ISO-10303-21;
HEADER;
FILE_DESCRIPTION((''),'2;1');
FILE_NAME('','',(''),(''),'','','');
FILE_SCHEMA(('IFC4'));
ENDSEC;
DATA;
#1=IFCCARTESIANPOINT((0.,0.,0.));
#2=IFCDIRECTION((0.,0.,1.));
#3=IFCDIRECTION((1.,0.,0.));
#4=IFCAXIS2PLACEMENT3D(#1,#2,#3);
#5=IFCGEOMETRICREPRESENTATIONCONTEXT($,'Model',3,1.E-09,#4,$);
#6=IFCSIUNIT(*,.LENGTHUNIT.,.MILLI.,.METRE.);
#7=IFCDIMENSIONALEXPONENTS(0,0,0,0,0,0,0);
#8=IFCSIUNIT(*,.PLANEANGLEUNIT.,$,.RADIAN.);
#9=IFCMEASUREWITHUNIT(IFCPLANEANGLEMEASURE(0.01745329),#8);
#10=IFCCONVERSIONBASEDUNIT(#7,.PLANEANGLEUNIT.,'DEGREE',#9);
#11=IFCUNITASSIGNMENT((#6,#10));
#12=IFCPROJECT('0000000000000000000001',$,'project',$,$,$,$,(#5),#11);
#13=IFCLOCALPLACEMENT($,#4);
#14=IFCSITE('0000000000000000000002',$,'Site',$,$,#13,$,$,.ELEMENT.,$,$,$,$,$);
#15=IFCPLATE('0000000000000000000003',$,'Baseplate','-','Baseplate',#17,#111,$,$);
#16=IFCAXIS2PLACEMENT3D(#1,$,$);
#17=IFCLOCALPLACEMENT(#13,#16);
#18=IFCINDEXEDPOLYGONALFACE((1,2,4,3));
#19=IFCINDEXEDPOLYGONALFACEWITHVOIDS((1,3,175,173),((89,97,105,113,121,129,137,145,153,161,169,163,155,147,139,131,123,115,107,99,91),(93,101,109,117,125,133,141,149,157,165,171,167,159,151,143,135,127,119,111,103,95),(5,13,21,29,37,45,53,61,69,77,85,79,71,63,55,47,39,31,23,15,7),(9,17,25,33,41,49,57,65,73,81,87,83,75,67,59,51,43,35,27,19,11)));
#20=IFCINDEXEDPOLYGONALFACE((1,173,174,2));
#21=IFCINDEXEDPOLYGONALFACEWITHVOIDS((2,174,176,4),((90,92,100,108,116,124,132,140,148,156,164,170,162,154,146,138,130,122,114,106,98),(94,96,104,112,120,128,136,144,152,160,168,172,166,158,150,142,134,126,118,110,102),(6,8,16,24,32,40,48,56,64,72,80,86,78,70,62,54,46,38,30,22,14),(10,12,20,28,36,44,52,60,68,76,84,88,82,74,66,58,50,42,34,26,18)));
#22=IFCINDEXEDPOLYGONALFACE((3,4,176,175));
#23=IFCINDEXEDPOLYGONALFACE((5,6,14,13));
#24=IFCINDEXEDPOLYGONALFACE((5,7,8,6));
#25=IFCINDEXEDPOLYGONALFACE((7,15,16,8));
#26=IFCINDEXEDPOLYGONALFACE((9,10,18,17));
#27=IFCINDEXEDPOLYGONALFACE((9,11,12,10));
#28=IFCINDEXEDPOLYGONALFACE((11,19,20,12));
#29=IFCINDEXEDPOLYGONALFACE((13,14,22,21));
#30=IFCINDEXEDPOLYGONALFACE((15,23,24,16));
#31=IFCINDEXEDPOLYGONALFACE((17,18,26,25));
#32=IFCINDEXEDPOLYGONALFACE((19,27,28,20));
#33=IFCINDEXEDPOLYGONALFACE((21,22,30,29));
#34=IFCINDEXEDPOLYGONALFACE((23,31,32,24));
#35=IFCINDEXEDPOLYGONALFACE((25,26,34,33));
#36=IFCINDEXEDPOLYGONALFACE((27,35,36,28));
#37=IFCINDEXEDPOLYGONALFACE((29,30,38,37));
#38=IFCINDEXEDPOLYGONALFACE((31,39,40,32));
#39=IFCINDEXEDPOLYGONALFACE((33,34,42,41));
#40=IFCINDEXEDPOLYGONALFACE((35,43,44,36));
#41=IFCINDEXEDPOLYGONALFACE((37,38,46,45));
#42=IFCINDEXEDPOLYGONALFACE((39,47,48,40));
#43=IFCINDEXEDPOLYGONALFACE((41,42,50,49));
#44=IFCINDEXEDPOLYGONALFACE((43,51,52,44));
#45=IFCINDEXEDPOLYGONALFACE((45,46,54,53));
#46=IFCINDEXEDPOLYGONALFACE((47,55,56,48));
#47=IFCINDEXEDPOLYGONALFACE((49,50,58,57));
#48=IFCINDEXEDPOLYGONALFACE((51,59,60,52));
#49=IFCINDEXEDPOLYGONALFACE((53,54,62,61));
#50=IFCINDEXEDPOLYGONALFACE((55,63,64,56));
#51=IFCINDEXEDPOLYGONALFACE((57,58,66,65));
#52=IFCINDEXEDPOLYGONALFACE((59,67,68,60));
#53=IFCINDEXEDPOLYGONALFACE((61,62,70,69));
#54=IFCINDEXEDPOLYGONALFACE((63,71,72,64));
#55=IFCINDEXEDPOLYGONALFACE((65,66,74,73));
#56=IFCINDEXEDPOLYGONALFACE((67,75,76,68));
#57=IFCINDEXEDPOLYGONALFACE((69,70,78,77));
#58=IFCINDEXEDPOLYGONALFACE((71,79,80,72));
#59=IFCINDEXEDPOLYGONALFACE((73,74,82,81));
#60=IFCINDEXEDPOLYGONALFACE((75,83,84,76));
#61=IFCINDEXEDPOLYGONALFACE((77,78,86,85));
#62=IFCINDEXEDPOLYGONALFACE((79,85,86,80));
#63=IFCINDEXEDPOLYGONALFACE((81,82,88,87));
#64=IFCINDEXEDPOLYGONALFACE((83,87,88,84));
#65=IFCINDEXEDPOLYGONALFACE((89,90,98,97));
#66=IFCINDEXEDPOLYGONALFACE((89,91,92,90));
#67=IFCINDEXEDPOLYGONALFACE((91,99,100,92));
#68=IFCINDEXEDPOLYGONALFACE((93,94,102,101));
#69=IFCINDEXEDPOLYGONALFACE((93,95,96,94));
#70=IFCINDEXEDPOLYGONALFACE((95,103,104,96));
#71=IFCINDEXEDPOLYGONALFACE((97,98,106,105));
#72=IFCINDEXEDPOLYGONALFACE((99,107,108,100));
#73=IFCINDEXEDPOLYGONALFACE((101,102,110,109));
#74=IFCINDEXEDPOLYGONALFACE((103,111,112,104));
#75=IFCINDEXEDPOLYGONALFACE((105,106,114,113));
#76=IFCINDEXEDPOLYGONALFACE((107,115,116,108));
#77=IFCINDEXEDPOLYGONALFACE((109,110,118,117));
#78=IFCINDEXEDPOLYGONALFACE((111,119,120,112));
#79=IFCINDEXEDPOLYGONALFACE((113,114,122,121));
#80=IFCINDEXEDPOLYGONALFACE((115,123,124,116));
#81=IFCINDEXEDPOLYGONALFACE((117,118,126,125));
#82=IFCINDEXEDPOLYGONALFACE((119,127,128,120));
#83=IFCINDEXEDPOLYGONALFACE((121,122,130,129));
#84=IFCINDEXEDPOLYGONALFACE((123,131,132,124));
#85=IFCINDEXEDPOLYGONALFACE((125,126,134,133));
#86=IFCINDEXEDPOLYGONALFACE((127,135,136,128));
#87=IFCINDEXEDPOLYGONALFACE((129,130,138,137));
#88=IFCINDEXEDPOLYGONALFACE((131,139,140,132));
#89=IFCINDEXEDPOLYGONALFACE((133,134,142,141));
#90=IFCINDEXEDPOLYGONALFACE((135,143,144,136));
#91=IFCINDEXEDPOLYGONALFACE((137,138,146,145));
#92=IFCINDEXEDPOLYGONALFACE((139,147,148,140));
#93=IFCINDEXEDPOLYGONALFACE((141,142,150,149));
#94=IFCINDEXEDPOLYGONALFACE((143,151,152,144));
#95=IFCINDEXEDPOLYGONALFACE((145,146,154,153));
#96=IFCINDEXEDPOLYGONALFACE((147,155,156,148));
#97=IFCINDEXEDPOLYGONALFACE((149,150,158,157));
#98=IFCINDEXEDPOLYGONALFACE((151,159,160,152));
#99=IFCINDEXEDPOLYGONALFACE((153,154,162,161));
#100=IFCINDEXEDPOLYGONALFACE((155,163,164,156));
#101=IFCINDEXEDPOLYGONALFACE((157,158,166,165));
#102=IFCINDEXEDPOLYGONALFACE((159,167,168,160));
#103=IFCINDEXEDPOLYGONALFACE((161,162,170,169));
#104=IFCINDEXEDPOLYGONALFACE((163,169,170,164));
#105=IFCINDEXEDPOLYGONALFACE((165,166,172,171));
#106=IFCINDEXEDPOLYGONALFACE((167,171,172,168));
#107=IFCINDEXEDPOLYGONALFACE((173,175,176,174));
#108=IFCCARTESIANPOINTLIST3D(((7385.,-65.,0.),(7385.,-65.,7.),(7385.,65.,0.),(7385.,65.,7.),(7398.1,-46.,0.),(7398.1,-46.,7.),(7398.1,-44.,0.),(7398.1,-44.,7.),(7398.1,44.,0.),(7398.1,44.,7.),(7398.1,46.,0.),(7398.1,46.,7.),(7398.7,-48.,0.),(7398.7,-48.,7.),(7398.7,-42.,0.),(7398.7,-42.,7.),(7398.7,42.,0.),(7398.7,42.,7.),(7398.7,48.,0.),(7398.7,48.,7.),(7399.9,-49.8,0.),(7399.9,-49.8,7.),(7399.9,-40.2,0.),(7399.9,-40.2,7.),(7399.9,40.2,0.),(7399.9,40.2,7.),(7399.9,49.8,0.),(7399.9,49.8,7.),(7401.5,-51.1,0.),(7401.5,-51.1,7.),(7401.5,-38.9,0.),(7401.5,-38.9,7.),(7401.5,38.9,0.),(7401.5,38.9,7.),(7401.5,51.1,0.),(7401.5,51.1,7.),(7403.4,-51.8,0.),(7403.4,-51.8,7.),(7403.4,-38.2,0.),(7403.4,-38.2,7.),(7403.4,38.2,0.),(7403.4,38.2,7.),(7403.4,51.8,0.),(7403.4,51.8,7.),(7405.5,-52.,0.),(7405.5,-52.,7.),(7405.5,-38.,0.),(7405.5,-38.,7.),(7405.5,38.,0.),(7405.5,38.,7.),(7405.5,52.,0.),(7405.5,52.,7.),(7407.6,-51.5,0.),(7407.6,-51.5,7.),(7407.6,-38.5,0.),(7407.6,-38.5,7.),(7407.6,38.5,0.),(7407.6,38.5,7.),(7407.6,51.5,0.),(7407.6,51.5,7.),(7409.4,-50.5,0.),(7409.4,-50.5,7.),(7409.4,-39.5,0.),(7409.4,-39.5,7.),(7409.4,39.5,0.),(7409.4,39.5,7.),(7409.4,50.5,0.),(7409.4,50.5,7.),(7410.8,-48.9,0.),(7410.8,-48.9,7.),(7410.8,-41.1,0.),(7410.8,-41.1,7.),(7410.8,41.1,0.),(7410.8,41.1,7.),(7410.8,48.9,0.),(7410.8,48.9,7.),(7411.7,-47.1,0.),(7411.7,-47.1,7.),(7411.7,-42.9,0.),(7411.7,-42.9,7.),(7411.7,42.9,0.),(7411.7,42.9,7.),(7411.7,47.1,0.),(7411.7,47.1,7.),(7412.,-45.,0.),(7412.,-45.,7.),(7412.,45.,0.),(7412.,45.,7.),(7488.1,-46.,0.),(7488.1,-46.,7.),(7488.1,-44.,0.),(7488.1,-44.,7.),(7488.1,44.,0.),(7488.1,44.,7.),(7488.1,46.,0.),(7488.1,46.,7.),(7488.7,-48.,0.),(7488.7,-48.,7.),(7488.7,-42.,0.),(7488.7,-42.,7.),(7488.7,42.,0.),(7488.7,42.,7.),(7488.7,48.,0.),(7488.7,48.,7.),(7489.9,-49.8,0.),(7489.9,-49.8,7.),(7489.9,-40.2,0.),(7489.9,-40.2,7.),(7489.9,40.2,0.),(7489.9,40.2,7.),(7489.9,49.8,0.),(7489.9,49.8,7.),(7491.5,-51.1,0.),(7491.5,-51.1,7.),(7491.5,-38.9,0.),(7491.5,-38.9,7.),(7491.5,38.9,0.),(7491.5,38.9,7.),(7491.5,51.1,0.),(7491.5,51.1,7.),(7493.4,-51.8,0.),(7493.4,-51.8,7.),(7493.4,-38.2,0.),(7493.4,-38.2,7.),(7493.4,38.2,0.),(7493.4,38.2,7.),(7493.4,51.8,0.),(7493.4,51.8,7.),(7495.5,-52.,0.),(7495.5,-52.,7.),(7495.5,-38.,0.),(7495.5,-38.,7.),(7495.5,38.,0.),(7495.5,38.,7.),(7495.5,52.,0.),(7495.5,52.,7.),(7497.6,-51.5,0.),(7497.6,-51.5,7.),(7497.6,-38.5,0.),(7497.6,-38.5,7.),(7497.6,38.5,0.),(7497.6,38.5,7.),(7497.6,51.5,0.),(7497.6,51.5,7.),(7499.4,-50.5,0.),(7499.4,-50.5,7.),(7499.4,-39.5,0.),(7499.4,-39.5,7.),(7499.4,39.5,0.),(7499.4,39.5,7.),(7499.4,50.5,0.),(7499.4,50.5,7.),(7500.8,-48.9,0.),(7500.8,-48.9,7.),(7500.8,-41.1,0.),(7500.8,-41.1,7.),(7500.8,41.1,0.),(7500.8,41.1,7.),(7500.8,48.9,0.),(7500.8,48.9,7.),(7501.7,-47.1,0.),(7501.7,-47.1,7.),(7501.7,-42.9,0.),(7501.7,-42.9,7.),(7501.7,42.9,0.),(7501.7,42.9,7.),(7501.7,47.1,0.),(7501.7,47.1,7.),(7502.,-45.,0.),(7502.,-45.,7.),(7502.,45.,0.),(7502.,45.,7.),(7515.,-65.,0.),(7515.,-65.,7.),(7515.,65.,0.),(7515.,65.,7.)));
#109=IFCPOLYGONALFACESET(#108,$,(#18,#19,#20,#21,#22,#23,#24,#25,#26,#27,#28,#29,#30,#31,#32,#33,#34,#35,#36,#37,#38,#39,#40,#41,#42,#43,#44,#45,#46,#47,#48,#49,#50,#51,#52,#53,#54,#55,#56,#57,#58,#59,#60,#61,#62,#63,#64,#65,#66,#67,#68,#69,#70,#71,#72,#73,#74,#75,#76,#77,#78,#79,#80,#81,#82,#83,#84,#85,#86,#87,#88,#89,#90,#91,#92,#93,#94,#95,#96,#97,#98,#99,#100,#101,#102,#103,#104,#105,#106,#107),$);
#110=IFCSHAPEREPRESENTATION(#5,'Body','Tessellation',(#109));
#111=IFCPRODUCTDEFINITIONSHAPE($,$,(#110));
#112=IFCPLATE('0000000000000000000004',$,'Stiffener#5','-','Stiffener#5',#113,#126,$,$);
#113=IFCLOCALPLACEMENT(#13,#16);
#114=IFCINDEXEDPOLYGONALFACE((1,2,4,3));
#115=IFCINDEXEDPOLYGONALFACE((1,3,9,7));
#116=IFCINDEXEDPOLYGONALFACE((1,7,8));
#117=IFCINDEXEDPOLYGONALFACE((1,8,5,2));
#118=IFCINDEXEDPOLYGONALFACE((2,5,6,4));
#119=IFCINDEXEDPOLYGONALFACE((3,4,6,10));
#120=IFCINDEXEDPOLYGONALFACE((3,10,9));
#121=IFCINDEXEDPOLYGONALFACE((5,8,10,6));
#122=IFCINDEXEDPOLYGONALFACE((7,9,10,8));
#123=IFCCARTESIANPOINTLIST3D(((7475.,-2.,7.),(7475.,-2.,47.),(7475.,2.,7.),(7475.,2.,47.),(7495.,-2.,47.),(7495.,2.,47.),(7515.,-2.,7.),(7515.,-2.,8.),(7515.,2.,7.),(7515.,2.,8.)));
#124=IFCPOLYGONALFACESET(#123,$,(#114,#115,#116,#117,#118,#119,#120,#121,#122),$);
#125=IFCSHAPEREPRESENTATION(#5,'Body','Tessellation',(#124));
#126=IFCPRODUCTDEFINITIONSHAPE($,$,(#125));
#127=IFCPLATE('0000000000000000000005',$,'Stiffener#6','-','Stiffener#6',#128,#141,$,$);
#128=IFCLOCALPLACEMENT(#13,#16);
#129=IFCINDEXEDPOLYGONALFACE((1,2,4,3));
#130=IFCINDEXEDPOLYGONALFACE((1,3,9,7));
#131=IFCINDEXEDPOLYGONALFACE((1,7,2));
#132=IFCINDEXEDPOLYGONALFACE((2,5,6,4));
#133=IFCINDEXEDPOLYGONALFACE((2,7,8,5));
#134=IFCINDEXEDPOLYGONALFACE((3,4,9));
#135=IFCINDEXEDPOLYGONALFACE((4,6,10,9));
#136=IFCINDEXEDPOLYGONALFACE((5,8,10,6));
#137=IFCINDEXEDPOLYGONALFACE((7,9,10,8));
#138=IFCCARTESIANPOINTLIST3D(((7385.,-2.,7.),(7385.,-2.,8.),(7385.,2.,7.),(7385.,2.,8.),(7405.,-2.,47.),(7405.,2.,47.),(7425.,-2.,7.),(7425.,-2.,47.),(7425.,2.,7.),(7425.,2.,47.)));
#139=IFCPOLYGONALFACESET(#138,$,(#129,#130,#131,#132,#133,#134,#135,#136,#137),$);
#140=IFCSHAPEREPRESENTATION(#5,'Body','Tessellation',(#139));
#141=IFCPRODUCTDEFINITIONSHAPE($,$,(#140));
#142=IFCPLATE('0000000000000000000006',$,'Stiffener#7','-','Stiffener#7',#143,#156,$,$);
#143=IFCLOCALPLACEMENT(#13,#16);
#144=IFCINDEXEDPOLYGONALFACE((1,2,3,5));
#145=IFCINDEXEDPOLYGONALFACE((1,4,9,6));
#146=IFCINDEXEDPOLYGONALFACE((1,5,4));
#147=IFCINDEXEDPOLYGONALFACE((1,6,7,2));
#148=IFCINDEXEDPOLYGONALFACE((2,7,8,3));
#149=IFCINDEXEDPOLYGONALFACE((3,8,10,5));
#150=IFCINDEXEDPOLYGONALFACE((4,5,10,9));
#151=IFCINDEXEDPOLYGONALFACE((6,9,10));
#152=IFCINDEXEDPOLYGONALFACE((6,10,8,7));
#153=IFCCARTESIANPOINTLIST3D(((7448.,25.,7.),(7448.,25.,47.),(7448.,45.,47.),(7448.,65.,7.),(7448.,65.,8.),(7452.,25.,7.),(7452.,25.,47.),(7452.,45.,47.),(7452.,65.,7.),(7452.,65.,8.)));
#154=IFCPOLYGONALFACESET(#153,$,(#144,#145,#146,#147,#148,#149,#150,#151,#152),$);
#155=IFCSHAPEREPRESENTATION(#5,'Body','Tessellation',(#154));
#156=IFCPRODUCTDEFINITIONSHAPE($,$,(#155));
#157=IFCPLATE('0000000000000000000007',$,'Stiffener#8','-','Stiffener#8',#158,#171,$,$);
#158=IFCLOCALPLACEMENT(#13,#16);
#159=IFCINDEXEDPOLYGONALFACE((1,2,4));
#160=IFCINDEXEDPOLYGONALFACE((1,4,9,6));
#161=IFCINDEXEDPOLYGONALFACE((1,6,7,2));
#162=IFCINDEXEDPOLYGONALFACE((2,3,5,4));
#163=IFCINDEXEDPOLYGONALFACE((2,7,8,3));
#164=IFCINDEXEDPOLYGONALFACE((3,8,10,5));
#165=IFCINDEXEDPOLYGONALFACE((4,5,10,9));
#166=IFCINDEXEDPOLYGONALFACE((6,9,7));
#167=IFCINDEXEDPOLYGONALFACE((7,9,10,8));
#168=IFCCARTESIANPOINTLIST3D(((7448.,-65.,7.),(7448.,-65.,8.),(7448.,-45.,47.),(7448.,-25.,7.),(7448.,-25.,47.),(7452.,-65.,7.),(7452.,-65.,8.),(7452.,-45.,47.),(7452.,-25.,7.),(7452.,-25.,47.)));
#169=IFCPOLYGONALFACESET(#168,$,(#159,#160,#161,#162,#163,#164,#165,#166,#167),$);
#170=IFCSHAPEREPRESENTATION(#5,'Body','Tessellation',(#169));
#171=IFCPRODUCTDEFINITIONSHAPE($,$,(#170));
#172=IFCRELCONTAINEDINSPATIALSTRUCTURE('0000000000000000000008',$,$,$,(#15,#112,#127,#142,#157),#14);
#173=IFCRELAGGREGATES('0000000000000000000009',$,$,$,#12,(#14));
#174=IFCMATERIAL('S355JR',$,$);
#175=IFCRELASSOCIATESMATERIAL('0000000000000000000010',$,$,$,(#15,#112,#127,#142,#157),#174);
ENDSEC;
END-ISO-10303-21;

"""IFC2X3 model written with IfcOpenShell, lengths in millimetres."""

from ifc_helpers import new_model, entity, si_unit, converted_unit, frame, frame_2d, origin, origin_with_axes, place, context, project, spatial, polyline, circle, outline, extrude, material, element, save


model = new_model("IFC2X3")

# Units and contexts
model_context = context("Model", 3, precision=1e-09, world=origin_with_axes())
ifc_project = project(units=[si_unit("LENGTHUNIT", "METRE", prefix="MILLI"), converted_unit("PLANEANGLEUNIT", "DEGREE", entity("IfcPlaneAngleMeasure", 0.01745329), si_unit("PLANEANGLEUNIT", "RADIAN"), dimensions=[0, 0, 0, 0, 0, 0, 0])], contexts=[model_context])

# Site
site_placement = place(None, origin_with_axes())
site = spatial("IfcSite", under=ifc_project, at=site_placement, Name="Site", CompositionType="ELEMENT")

# Shared definitions
ifc_material = material(Name="S355JR")

# Plate, openings
plate_1_placement = place(None, frame((7385.0, 65.0, 7.0), z_axis=(0.0, 0.0, -1.0), x_axis=(1.0, 0.0, 0.0)))
plate_1 = element("IfcPlate", 1, at=plate_1_placement, inside=site, material=ifc_material, Name="Baseplate", Description="-", ObjectType="Baseplate", context=model_context, shape_type="SweptSolid", body=[
    extrude(outline(polyline([(0.0, 0.0), (130.0, 0.0), (130.0, 130.0), (0.0, 130.0), (0.0, 0.0)])), origin_with_axes(), (0.0, 0.0, 1.0), 7.0),
])
opening_1_placement = place(plate_1_placement, frame((20.0, 65.0, 7.5), z_axis=(0.0, 0.0, -1.0), x_axis=(1.0, 0.0, 0.0)))
element("IfcOpeningElement", 2, at=opening_1_placement, cuts=plate_1, ObjectType="Opening", context=model_context, shape_type="SweptSolid", body=[
    extrude(circle(Radius=7.0, at=frame_2d((0.0, 45.0), x_axis=(1.0, 0.0))), origin(), (0.0, 0.0, 1.0), 8.0),
])
opening_2_placement = place(plate_1_placement, frame((20.0, 65.0, 7.5), z_axis=(0.0, 0.0, -1.0), x_axis=(1.0, 0.0, 0.0)))
element("IfcOpeningElement", 3, at=opening_2_placement, cuts=plate_1, ObjectType="Opening", context=model_context, shape_type="SweptSolid", body=[
    extrude(circle(Radius=7.0, at=frame_2d((0.0, -45.0), x_axis=(1.0, 0.0))), origin(), (0.0, 0.0, 1.0), 8.0),
])
opening_3_placement = place(plate_1_placement, frame((110.0, 65.0, 7.5), z_axis=(0.0, 0.0, -1.0), x_axis=(1.0, 0.0, 0.0)))
element("IfcOpeningElement", 4, at=opening_3_placement, cuts=plate_1, ObjectType="Opening", context=model_context, shape_type="SweptSolid", body=[
    extrude(circle(Radius=7.0, at=frame_2d((0.0, 45.0), x_axis=(1.0, 0.0))), origin(), (0.0, 0.0, 1.0), 8.0),
])
opening_4_placement = place(plate_1_placement, frame((110.0, 65.0, 7.5), z_axis=(0.0, 0.0, -1.0), x_axis=(1.0, 0.0, 0.0)))
element("IfcOpeningElement", 5, at=opening_4_placement, cuts=plate_1, ObjectType="Opening", context=model_context, shape_type="SweptSolid", body=[
    extrude(circle(Radius=7.0, at=frame_2d((0.0, -45.0), x_axis=(1.0, 0.0))), origin(), (0.0, 0.0, 1.0), 8.0),
])

# Plates, openings
plate_2_placement = place(None, frame((7475.0, -2.0, 7.0), z_axis=(0.0, 1.0, 0.0), x_axis=(0.0, 0.0, 1.0)))
plate_2 = element("IfcPlate", 6, at=plate_2_placement, inside=site, material=ifc_material, Name="Stiffener#5", Description="-", ObjectType="Stiffener#5", context=model_context, shape_type="SweptSolid", body=[
    extrude(outline(polyline([(0.0, 0.0), (40.0, 0.0), (40.0, 40.0), (0.0, 40.0), (0.0, 0.0)])), origin_with_axes(), (0.0, 0.0, 1.0), 4.0),
])
opening_5_placement = place(plate_2_placement, frame((0.0, 0.0, 0.0), z_axis=(0.0, 0.0, 1.0), x_axis=(1.0, 0.0, 0.0)))
element("IfcOpeningElement", 7, at=opening_5_placement, cuts=plate_2, ObjectType="Opening", context=model_context, shape_type="SweptSolid", body=[
    extrude(outline(polyline([(40.0, 40.0), (1.0, 40.0), (40.0, 20.0), (40.0, 40.0)])), origin(), (0.0, 0.0, 1.0), 4.0),
])
plate_3_placement = place(None, frame((7425.0, -2.0, 7.0), z_axis=(0.0, 1.0, 0.0), x_axis=(-1.0, 0.0, 0.0)))
plate_3 = element("IfcPlate", 8, at=plate_3_placement, inside=site, material=ifc_material, Name="Stiffener#6", Description="-", ObjectType="Stiffener#6", context=model_context, shape_type="SweptSolid", body=[
    extrude(outline(polyline([(0.0, 0.0), (40.0, 0.0), (40.0, 40.0), (0.0, 40.0), (0.0, 0.0)])), origin_with_axes(), (0.0, 0.0, 1.0), 4.0),
])
opening_6_placement = place(plate_3_placement, frame((0.0, 0.0, 0.0), z_axis=(0.0, 0.0, 1.0), x_axis=(1.0, 0.0, 0.0)))
element("IfcOpeningElement", 9, at=opening_6_placement, cuts=plate_3, ObjectType="Opening", context=model_context, shape_type="SweptSolid", body=[
    extrude(outline(polyline([(40.0, 40.0), (20.0, 40.0), (40.0, 1.0), (40.0, 40.0)])), origin(), (0.0, 0.0, 1.0), 4.0),
])
plate_4_placement = place(None, frame((7452.0, 25.0, 7.0), z_axis=(-1.0, 0.0, 0.0), x_axis=(0.0, 0.0, 1.0)))
plate_4 = element("IfcPlate", 10, at=plate_4_placement, inside=site, material=ifc_material, Name="Stiffener#7", Description="-", ObjectType="Stiffener#7", context=model_context, shape_type="SweptSolid", body=[
    extrude(outline(polyline([(0.0, 0.0), (40.0, 0.0), (40.0, 40.0), (0.0, 40.0), (0.0, 0.0)])), origin_with_axes(), (0.0, 0.0, 1.0), 4.0),
])
opening_7_placement = place(plate_4_placement, frame((0.0, 0.0, 0.0), z_axis=(0.0, 0.0, 1.0), x_axis=(1.0, 0.0, 0.0)))
element("IfcOpeningElement", 11, at=opening_7_placement, cuts=plate_4, ObjectType="Opening", context=model_context, shape_type="SweptSolid", body=[
    extrude(outline(polyline([(40.0, 40.0), (1.0, 40.0), (40.0, 20.0), (40.0, 40.0)])), origin(), (0.0, 0.0, 1.0), 4.0),
])
plate_5_placement = place(None, frame((7452.0, -25.0, 7.0), z_axis=(-1.0, 0.0, 0.0), x_axis=(0.0, -1.0, 0.0)))
plate_5 = element("IfcPlate", 12, at=plate_5_placement, inside=site, material=ifc_material, Name="Stiffener#8", Description="-", ObjectType="Stiffener#8", context=model_context, shape_type="SweptSolid", body=[
    extrude(outline(polyline([(0.0, 0.0), (40.0, 0.0), (40.0, 40.0), (0.0, 40.0), (0.0, 0.0)])), origin_with_axes(), (0.0, 0.0, 1.0), 4.0),
])
opening_8_placement = place(plate_5_placement, frame((0.0, 0.0, 0.0), z_axis=(0.0, 0.0, 1.0), x_axis=(1.0, 0.0, 0.0)))
element("IfcOpeningElement", 13, at=opening_8_placement, cuts=plate_5, ObjectType="Opening", context=model_context, shape_type="SweptSolid", body=[
    extrude(outline(polyline([(40.0, 40.0), (20.0, 40.0), (40.0, 1.0), (40.0, 40.0)])), origin(), (0.0, 0.0, 1.0), 4.0),
])

save(model, "model.ifc")
